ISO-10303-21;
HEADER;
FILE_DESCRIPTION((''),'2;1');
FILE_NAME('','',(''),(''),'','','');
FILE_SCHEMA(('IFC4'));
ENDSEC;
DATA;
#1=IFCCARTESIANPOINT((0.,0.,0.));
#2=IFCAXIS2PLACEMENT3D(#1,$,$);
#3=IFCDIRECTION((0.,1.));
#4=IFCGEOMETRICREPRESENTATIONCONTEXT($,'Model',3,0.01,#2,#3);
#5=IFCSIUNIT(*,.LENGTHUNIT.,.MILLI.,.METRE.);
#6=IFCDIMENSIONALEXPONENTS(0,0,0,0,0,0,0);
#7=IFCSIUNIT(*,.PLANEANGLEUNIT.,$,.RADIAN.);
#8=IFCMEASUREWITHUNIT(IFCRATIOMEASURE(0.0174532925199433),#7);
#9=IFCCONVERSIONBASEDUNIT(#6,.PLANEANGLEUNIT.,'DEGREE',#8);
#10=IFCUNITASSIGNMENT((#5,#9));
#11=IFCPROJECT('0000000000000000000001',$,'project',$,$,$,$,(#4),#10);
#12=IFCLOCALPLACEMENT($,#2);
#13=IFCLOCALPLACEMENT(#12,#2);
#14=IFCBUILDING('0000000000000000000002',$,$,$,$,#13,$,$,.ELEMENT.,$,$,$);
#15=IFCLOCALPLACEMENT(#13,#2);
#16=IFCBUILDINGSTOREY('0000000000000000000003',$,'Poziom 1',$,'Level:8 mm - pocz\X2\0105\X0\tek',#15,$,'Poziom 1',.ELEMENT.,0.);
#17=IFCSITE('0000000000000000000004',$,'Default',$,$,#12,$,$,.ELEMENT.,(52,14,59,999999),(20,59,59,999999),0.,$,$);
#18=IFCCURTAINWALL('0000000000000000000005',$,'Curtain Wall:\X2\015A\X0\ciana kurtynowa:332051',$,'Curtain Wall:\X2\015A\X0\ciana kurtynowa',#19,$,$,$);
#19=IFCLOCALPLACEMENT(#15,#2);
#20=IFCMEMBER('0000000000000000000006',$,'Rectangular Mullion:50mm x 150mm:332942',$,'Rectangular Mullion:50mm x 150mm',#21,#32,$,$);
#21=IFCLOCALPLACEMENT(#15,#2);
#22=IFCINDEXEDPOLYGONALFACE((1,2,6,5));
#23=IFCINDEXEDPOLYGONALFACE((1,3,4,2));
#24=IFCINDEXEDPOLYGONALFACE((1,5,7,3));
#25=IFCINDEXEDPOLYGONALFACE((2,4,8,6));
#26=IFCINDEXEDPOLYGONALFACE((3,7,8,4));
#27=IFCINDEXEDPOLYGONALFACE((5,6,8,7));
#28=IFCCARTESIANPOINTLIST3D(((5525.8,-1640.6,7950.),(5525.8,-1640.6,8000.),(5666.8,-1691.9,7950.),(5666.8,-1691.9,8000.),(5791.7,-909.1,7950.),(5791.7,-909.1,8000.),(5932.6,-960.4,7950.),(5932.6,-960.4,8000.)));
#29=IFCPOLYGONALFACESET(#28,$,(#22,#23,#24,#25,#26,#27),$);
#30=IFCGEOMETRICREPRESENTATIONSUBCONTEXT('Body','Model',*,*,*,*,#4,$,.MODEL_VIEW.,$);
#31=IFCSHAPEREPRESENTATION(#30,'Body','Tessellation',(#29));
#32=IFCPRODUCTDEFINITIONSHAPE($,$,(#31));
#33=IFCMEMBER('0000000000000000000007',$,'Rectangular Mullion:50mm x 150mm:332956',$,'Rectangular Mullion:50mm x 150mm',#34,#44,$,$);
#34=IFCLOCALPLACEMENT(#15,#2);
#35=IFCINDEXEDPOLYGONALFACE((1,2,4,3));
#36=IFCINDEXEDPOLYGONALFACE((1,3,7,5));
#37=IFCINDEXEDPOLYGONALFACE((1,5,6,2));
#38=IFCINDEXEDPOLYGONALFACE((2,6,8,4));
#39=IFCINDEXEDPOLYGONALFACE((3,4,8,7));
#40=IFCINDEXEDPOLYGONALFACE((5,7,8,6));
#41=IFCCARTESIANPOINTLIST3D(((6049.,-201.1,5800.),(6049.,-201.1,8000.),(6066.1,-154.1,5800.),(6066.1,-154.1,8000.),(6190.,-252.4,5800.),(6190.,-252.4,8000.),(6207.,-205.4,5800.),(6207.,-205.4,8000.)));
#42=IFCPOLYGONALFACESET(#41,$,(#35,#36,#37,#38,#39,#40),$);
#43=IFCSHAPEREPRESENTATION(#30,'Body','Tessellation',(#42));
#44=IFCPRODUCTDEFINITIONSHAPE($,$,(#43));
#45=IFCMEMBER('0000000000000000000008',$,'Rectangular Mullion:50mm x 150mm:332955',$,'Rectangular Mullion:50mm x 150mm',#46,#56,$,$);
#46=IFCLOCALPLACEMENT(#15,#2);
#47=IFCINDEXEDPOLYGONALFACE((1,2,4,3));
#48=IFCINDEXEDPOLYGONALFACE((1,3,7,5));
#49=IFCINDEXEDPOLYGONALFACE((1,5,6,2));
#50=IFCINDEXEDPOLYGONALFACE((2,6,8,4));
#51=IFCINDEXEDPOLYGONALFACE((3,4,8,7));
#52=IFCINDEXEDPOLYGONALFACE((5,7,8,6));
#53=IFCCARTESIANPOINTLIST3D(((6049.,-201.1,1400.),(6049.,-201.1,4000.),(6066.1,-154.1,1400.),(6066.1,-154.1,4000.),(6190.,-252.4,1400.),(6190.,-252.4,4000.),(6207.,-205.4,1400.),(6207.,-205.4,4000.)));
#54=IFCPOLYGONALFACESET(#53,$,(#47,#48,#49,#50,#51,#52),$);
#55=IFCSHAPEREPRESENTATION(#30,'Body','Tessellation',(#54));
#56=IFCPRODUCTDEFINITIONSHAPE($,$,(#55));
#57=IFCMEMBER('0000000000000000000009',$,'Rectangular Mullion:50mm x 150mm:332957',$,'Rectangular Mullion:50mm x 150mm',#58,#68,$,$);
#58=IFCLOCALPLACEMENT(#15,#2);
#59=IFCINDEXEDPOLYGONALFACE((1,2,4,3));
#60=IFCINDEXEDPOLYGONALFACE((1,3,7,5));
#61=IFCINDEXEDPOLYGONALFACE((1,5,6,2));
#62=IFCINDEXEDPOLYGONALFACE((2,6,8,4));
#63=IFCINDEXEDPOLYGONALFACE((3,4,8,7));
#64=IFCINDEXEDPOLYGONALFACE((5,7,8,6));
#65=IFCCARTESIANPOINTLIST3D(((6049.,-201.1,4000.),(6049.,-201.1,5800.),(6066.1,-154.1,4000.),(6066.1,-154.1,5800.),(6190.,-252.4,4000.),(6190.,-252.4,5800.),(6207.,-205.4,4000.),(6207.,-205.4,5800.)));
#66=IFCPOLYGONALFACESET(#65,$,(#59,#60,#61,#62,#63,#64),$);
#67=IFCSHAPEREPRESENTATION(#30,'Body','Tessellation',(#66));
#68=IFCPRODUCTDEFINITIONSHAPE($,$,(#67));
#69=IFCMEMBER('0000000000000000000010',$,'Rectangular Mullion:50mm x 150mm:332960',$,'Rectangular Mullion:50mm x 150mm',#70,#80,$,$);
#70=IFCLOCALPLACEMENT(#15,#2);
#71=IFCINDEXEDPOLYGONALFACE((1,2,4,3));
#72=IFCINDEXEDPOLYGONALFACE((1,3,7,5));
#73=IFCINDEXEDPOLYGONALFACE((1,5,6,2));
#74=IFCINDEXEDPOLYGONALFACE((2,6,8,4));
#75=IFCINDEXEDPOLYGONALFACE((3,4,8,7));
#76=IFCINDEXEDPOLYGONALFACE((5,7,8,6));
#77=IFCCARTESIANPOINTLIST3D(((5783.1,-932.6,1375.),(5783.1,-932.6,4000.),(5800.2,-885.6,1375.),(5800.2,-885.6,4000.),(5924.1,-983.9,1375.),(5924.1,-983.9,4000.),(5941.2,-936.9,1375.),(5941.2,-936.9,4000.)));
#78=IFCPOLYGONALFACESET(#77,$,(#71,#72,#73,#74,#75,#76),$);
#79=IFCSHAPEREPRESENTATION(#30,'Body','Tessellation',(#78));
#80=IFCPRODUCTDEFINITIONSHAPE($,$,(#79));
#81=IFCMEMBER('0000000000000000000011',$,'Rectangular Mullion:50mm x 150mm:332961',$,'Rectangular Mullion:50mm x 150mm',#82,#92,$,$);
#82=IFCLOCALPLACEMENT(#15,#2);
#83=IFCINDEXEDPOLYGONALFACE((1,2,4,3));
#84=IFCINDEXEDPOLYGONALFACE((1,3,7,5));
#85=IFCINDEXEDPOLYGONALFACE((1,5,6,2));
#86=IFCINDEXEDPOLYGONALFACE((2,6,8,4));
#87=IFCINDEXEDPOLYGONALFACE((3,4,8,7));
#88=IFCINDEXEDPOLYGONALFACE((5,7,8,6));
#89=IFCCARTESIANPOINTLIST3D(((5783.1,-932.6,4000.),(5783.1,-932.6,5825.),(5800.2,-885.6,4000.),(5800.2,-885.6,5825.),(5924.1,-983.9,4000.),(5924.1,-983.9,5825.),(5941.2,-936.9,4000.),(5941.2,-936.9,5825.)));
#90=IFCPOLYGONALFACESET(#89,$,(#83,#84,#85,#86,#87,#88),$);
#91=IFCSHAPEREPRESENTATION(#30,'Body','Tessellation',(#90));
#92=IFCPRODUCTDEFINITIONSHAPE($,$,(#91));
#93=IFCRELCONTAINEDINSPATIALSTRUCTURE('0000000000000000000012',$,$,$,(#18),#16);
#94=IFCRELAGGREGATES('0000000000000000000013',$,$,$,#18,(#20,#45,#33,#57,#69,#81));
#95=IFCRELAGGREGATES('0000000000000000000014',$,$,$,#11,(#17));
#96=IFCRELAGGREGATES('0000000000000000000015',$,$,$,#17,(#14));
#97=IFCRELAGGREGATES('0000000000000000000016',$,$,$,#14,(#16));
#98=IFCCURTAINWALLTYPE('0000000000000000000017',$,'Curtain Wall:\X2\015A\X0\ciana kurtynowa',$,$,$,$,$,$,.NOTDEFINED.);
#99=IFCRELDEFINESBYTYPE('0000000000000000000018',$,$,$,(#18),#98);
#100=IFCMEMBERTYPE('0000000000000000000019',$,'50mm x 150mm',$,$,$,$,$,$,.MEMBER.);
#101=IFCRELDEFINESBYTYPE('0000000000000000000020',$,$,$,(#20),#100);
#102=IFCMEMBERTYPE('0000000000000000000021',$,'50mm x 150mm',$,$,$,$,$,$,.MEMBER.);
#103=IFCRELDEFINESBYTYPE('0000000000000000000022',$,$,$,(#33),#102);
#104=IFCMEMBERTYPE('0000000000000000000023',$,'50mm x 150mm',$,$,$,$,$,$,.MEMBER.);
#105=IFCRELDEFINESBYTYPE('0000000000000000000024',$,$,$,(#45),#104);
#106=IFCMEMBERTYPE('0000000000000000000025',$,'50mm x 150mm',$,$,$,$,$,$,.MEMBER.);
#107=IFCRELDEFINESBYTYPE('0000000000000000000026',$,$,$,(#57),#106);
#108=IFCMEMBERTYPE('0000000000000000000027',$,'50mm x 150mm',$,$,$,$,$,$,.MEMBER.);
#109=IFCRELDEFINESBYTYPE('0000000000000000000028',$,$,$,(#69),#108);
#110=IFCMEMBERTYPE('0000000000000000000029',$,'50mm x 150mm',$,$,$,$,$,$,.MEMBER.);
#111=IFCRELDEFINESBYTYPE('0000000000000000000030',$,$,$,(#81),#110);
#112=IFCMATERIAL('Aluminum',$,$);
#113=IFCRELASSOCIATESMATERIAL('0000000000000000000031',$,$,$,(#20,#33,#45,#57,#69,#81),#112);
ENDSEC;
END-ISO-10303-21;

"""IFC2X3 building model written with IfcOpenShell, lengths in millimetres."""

from ifc_helpers import new_model, entity, si_unit, converted_unit, direction, frame, origin, origin_2d_with_axis, place, context, subcontext, project, spatial, rectangle, extrude, source, transform, mapped, material, type_object, type_shapes, element, aggregate, save


model = new_model("IFC2X3")

# Units and contexts
model_context = context("Model", 3, precision=0.01, world=origin(), true_north=direction((0.0, 1.0)))
body_context = subcontext(model_context, "Body", "Model", "MODEL_VIEW")
ifc_project = project(units=[si_unit("LENGTHUNIT", "METRE", prefix="MILLI"), converted_unit("PLANEANGLEUNIT", "DEGREE", entity("IfcRatioMeasure", 0.0174532925199433), si_unit("PLANEANGLEUNIT", "RADIAN"), dimensions=[0, 0, 0, 0, 0, 0, 0])], contexts=[model_context])

# Site, building, storey
site_placement = place(None, origin())
site = spatial("IfcSite", under=ifc_project, at=site_placement, Name="Default", CompositionType="ELEMENT", RefLatitude=(52, 14, 59, 999999), RefLongitude=(20, 59, 59, 999999), RefElevation=0.0)
building_placement = place(site_placement, origin())
building = spatial("IfcBuilding", under=site, at=building_placement, CompositionType="ELEMENT")
storey_placement = place(building_placement, origin())
storey = spatial("IfcBuildingStorey", under=building, at=storey_placement, Name="Poziom 1", ObjectType="Level:8 mm - początek", LongName="Poziom 1", CompositionType="ELEMENT", Elevation=0.0)

# Curtain wall, members
curtain_wall_type = type_object("IfcCurtainWallType", Name="Curtain Wall:Ściana kurtynowa", PredefinedType="NOTDEFINED")
curtain_wall_placement = place(storey_placement, origin())
curtain_wall = element("IfcCurtainWall", 1, at=curtain_wall_placement, inside=storey, type_object=curtain_wall_type, Name="Curtain Wall:Ściana kurtynowa:332051", ObjectType="Curtain Wall:Ściana kurtynowa")
ifc_material_1 = material(Name="Aluminum")
member_type_1 = type_object("IfcMemberType", Name="50mm x 150mm", PredefinedType="MEMBER")
shared_shape_1 = source(origin(), body_context, "Body", "SweptSolid", [
    extrude(rectangle(XDim=150.0, YDim=50.0, at=origin_2d_with_axis()), frame((-25.0, 0.0, -778.3), z_axis=(0.0, 0.0, 1.0), x_axis=(0.0, -1.0, 0.0)), (0.0, 0.0, 1.0), 778.3),
])
type_shapes(member_type_1, [shared_shape_1])
member_1_placement = place(storey_placement, frame((5862.1, -934.8, 8000.0), z_axis=(0.341586, 0.939851, 0.0), x_axis=(0.0, 0.0, 1.0)))
member_1 = element("IfcMember", 2, at=member_1_placement, type_object=member_type_1, material=ifc_material_1, Name="Rectangular Mullion:50mm x 150mm:332942", ObjectType="Rectangular Mullion:50mm x 150mm", context=body_context, shape_type="MappedRepresentation", body=[
    mapped(shared_shape_1, transform((0.0, 0.0, 0.0), scale=1.0)),
])
member_type_2 = type_object("IfcMemberType", Name="50mm x 150mm", PredefinedType="MEMBER")
shared_shape_2 = source(origin(), body_context, "Body", "SweptSolid", [
    extrude(rectangle(XDim=150.0, YDim=50.0, at=origin_2d_with_axis()), frame((0.0, 0.0, -2200.0), z_axis=(0.0, 0.0, 1.0), x_axis=(0.0, -1.0, 0.0)), (0.0, 0.0, 1.0), 2200.0),
])
type_shapes(member_type_2, [shared_shape_2])
member_2_placement = place(storey_placement, frame((6128.0, -203.2, 5800.0), z_axis=(0.0, 0.0, -1.0), x_axis=(0.341586, 0.939851, 0.0)))
member_2 = element("IfcMember", 3, at=member_2_placement, type_object=member_type_2, material=ifc_material_1, Name="Rectangular Mullion:50mm x 150mm:332956", ObjectType="Rectangular Mullion:50mm x 150mm", context=body_context, shape_type="MappedRepresentation", body=[
    mapped(shared_shape_2, transform((0.0, 0.0, 0.0), scale=1.0)),
])
member_type_3 = type_object("IfcMemberType", Name="50mm x 150mm", PredefinedType="MEMBER")
shared_shape_3 = source(origin(), body_context, "Body", "SweptSolid", [
    extrude(rectangle(XDim=150.0, YDim=50.0, at=origin_2d_with_axis()), frame((0.0, 0.0, -2600.0), z_axis=(0.0, 0.0, 1.0), x_axis=(0.0, -1.0, 0.0)), (0.0, 0.0, 1.0), 2600.0),
])
type_shapes(member_type_3, [shared_shape_3])
member_3_placement = place(storey_placement, frame((6128.0, -203.2, 1400.0), z_axis=(0.0, 0.0, -1.0), x_axis=(0.341586, 0.939851, 0.0)))
member_3 = element("IfcMember", 4, at=member_3_placement, type_object=member_type_3, material=ifc_material_1, Name="Rectangular Mullion:50mm x 150mm:332955", ObjectType="Rectangular Mullion:50mm x 150mm", context=body_context, shape_type="MappedRepresentation", body=[
    mapped(shared_shape_3, transform((0.0, 0.0, 0.0), scale=1.0)),
])
member_type_4 = type_object("IfcMemberType", Name="50mm x 150mm", PredefinedType="MEMBER")
shared_shape_4 = source(origin(), body_context, "Body", "SweptSolid", [
    extrude(rectangle(XDim=150.0, YDim=50.0, at=origin_2d_with_axis()), frame((0.0, 0.0, -1800.0), z_axis=(0.0, 0.0, 1.0), x_axis=(0.0, -1.0, 0.0)), (0.0, 0.0, 1.0), 1800.0),
])
type_shapes(member_type_4, [shared_shape_4])
member_4_placement = place(storey_placement, frame((6128.0, -203.2, 4000.0), z_axis=(0.0, 0.0, -1.0), x_axis=(0.341586, 0.939851, 0.0)))
member_4 = element("IfcMember", 5, at=member_4_placement, type_object=member_type_4, material=ifc_material_1, Name="Rectangular Mullion:50mm x 150mm:332957", ObjectType="Rectangular Mullion:50mm x 150mm", context=body_context, shape_type="MappedRepresentation", body=[
    mapped(shared_shape_4, transform((0.0, 0.0, 0.0), scale=1.0)),
])
member_type_5 = type_object("IfcMemberType", Name="50mm x 150mm", PredefinedType="MEMBER")
shared_shape_5 = source(origin(), body_context, "Body", "SweptSolid", [
    extrude(rectangle(XDim=150.0, YDim=50.0, at=origin_2d_with_axis()), frame((0.0, 0.0, -2625.0), z_axis=(0.0, 0.0, 1.0), x_axis=(0.0, -1.0, 0.0)), (0.0, 0.0, 1.0), 2625.0),
])
type_shapes(member_type_5, [shared_shape_5])
member_5_placement = place(storey_placement, frame((5862.1, -934.8, 1375.0), z_axis=(0.0, 0.0, -1.0), x_axis=(0.341586, 0.939851, 0.0)))
member_5 = element("IfcMember", 6, at=member_5_placement, type_object=member_type_5, material=ifc_material_1, Name="Rectangular Mullion:50mm x 150mm:332960", ObjectType="Rectangular Mullion:50mm x 150mm", context=body_context, shape_type="MappedRepresentation", body=[
    mapped(shared_shape_5, transform((0.0, 0.0, 0.0), scale=1.0)),
])
member_type_6 = type_object("IfcMemberType", Name="50mm x 150mm", PredefinedType="MEMBER")
shared_shape_6 = source(origin(), body_context, "Body", "SweptSolid", [
    extrude(rectangle(XDim=150.0, YDim=50.0, at=origin_2d_with_axis()), frame((0.0, 0.0, -1825.0), z_axis=(0.0, 0.0, 1.0), x_axis=(0.0, -1.0, 0.0)), (0.0, 0.0, 1.0), 1825.0),
])
type_shapes(member_type_6, [shared_shape_6])
member_6_placement = place(storey_placement, frame((5862.1, -934.8, 4000.0), z_axis=(0.0, 0.0, -1.0), x_axis=(0.341586, 0.939851, 0.0)))
member_6 = element("IfcMember", 7, at=member_6_placement, type_object=member_type_6, material=ifc_material_1, Name="Rectangular Mullion:50mm x 150mm:332961", ObjectType="Rectangular Mullion:50mm x 150mm", context=body_context, shape_type="MappedRepresentation", body=[
    mapped(shared_shape_6, transform((0.0, 0.0, 0.0), scale=1.0)),
])
aggregate(curtain_wall, [member_1, member_3, member_2, member_4, member_5, member_6])

save(model, "model.ifc")
